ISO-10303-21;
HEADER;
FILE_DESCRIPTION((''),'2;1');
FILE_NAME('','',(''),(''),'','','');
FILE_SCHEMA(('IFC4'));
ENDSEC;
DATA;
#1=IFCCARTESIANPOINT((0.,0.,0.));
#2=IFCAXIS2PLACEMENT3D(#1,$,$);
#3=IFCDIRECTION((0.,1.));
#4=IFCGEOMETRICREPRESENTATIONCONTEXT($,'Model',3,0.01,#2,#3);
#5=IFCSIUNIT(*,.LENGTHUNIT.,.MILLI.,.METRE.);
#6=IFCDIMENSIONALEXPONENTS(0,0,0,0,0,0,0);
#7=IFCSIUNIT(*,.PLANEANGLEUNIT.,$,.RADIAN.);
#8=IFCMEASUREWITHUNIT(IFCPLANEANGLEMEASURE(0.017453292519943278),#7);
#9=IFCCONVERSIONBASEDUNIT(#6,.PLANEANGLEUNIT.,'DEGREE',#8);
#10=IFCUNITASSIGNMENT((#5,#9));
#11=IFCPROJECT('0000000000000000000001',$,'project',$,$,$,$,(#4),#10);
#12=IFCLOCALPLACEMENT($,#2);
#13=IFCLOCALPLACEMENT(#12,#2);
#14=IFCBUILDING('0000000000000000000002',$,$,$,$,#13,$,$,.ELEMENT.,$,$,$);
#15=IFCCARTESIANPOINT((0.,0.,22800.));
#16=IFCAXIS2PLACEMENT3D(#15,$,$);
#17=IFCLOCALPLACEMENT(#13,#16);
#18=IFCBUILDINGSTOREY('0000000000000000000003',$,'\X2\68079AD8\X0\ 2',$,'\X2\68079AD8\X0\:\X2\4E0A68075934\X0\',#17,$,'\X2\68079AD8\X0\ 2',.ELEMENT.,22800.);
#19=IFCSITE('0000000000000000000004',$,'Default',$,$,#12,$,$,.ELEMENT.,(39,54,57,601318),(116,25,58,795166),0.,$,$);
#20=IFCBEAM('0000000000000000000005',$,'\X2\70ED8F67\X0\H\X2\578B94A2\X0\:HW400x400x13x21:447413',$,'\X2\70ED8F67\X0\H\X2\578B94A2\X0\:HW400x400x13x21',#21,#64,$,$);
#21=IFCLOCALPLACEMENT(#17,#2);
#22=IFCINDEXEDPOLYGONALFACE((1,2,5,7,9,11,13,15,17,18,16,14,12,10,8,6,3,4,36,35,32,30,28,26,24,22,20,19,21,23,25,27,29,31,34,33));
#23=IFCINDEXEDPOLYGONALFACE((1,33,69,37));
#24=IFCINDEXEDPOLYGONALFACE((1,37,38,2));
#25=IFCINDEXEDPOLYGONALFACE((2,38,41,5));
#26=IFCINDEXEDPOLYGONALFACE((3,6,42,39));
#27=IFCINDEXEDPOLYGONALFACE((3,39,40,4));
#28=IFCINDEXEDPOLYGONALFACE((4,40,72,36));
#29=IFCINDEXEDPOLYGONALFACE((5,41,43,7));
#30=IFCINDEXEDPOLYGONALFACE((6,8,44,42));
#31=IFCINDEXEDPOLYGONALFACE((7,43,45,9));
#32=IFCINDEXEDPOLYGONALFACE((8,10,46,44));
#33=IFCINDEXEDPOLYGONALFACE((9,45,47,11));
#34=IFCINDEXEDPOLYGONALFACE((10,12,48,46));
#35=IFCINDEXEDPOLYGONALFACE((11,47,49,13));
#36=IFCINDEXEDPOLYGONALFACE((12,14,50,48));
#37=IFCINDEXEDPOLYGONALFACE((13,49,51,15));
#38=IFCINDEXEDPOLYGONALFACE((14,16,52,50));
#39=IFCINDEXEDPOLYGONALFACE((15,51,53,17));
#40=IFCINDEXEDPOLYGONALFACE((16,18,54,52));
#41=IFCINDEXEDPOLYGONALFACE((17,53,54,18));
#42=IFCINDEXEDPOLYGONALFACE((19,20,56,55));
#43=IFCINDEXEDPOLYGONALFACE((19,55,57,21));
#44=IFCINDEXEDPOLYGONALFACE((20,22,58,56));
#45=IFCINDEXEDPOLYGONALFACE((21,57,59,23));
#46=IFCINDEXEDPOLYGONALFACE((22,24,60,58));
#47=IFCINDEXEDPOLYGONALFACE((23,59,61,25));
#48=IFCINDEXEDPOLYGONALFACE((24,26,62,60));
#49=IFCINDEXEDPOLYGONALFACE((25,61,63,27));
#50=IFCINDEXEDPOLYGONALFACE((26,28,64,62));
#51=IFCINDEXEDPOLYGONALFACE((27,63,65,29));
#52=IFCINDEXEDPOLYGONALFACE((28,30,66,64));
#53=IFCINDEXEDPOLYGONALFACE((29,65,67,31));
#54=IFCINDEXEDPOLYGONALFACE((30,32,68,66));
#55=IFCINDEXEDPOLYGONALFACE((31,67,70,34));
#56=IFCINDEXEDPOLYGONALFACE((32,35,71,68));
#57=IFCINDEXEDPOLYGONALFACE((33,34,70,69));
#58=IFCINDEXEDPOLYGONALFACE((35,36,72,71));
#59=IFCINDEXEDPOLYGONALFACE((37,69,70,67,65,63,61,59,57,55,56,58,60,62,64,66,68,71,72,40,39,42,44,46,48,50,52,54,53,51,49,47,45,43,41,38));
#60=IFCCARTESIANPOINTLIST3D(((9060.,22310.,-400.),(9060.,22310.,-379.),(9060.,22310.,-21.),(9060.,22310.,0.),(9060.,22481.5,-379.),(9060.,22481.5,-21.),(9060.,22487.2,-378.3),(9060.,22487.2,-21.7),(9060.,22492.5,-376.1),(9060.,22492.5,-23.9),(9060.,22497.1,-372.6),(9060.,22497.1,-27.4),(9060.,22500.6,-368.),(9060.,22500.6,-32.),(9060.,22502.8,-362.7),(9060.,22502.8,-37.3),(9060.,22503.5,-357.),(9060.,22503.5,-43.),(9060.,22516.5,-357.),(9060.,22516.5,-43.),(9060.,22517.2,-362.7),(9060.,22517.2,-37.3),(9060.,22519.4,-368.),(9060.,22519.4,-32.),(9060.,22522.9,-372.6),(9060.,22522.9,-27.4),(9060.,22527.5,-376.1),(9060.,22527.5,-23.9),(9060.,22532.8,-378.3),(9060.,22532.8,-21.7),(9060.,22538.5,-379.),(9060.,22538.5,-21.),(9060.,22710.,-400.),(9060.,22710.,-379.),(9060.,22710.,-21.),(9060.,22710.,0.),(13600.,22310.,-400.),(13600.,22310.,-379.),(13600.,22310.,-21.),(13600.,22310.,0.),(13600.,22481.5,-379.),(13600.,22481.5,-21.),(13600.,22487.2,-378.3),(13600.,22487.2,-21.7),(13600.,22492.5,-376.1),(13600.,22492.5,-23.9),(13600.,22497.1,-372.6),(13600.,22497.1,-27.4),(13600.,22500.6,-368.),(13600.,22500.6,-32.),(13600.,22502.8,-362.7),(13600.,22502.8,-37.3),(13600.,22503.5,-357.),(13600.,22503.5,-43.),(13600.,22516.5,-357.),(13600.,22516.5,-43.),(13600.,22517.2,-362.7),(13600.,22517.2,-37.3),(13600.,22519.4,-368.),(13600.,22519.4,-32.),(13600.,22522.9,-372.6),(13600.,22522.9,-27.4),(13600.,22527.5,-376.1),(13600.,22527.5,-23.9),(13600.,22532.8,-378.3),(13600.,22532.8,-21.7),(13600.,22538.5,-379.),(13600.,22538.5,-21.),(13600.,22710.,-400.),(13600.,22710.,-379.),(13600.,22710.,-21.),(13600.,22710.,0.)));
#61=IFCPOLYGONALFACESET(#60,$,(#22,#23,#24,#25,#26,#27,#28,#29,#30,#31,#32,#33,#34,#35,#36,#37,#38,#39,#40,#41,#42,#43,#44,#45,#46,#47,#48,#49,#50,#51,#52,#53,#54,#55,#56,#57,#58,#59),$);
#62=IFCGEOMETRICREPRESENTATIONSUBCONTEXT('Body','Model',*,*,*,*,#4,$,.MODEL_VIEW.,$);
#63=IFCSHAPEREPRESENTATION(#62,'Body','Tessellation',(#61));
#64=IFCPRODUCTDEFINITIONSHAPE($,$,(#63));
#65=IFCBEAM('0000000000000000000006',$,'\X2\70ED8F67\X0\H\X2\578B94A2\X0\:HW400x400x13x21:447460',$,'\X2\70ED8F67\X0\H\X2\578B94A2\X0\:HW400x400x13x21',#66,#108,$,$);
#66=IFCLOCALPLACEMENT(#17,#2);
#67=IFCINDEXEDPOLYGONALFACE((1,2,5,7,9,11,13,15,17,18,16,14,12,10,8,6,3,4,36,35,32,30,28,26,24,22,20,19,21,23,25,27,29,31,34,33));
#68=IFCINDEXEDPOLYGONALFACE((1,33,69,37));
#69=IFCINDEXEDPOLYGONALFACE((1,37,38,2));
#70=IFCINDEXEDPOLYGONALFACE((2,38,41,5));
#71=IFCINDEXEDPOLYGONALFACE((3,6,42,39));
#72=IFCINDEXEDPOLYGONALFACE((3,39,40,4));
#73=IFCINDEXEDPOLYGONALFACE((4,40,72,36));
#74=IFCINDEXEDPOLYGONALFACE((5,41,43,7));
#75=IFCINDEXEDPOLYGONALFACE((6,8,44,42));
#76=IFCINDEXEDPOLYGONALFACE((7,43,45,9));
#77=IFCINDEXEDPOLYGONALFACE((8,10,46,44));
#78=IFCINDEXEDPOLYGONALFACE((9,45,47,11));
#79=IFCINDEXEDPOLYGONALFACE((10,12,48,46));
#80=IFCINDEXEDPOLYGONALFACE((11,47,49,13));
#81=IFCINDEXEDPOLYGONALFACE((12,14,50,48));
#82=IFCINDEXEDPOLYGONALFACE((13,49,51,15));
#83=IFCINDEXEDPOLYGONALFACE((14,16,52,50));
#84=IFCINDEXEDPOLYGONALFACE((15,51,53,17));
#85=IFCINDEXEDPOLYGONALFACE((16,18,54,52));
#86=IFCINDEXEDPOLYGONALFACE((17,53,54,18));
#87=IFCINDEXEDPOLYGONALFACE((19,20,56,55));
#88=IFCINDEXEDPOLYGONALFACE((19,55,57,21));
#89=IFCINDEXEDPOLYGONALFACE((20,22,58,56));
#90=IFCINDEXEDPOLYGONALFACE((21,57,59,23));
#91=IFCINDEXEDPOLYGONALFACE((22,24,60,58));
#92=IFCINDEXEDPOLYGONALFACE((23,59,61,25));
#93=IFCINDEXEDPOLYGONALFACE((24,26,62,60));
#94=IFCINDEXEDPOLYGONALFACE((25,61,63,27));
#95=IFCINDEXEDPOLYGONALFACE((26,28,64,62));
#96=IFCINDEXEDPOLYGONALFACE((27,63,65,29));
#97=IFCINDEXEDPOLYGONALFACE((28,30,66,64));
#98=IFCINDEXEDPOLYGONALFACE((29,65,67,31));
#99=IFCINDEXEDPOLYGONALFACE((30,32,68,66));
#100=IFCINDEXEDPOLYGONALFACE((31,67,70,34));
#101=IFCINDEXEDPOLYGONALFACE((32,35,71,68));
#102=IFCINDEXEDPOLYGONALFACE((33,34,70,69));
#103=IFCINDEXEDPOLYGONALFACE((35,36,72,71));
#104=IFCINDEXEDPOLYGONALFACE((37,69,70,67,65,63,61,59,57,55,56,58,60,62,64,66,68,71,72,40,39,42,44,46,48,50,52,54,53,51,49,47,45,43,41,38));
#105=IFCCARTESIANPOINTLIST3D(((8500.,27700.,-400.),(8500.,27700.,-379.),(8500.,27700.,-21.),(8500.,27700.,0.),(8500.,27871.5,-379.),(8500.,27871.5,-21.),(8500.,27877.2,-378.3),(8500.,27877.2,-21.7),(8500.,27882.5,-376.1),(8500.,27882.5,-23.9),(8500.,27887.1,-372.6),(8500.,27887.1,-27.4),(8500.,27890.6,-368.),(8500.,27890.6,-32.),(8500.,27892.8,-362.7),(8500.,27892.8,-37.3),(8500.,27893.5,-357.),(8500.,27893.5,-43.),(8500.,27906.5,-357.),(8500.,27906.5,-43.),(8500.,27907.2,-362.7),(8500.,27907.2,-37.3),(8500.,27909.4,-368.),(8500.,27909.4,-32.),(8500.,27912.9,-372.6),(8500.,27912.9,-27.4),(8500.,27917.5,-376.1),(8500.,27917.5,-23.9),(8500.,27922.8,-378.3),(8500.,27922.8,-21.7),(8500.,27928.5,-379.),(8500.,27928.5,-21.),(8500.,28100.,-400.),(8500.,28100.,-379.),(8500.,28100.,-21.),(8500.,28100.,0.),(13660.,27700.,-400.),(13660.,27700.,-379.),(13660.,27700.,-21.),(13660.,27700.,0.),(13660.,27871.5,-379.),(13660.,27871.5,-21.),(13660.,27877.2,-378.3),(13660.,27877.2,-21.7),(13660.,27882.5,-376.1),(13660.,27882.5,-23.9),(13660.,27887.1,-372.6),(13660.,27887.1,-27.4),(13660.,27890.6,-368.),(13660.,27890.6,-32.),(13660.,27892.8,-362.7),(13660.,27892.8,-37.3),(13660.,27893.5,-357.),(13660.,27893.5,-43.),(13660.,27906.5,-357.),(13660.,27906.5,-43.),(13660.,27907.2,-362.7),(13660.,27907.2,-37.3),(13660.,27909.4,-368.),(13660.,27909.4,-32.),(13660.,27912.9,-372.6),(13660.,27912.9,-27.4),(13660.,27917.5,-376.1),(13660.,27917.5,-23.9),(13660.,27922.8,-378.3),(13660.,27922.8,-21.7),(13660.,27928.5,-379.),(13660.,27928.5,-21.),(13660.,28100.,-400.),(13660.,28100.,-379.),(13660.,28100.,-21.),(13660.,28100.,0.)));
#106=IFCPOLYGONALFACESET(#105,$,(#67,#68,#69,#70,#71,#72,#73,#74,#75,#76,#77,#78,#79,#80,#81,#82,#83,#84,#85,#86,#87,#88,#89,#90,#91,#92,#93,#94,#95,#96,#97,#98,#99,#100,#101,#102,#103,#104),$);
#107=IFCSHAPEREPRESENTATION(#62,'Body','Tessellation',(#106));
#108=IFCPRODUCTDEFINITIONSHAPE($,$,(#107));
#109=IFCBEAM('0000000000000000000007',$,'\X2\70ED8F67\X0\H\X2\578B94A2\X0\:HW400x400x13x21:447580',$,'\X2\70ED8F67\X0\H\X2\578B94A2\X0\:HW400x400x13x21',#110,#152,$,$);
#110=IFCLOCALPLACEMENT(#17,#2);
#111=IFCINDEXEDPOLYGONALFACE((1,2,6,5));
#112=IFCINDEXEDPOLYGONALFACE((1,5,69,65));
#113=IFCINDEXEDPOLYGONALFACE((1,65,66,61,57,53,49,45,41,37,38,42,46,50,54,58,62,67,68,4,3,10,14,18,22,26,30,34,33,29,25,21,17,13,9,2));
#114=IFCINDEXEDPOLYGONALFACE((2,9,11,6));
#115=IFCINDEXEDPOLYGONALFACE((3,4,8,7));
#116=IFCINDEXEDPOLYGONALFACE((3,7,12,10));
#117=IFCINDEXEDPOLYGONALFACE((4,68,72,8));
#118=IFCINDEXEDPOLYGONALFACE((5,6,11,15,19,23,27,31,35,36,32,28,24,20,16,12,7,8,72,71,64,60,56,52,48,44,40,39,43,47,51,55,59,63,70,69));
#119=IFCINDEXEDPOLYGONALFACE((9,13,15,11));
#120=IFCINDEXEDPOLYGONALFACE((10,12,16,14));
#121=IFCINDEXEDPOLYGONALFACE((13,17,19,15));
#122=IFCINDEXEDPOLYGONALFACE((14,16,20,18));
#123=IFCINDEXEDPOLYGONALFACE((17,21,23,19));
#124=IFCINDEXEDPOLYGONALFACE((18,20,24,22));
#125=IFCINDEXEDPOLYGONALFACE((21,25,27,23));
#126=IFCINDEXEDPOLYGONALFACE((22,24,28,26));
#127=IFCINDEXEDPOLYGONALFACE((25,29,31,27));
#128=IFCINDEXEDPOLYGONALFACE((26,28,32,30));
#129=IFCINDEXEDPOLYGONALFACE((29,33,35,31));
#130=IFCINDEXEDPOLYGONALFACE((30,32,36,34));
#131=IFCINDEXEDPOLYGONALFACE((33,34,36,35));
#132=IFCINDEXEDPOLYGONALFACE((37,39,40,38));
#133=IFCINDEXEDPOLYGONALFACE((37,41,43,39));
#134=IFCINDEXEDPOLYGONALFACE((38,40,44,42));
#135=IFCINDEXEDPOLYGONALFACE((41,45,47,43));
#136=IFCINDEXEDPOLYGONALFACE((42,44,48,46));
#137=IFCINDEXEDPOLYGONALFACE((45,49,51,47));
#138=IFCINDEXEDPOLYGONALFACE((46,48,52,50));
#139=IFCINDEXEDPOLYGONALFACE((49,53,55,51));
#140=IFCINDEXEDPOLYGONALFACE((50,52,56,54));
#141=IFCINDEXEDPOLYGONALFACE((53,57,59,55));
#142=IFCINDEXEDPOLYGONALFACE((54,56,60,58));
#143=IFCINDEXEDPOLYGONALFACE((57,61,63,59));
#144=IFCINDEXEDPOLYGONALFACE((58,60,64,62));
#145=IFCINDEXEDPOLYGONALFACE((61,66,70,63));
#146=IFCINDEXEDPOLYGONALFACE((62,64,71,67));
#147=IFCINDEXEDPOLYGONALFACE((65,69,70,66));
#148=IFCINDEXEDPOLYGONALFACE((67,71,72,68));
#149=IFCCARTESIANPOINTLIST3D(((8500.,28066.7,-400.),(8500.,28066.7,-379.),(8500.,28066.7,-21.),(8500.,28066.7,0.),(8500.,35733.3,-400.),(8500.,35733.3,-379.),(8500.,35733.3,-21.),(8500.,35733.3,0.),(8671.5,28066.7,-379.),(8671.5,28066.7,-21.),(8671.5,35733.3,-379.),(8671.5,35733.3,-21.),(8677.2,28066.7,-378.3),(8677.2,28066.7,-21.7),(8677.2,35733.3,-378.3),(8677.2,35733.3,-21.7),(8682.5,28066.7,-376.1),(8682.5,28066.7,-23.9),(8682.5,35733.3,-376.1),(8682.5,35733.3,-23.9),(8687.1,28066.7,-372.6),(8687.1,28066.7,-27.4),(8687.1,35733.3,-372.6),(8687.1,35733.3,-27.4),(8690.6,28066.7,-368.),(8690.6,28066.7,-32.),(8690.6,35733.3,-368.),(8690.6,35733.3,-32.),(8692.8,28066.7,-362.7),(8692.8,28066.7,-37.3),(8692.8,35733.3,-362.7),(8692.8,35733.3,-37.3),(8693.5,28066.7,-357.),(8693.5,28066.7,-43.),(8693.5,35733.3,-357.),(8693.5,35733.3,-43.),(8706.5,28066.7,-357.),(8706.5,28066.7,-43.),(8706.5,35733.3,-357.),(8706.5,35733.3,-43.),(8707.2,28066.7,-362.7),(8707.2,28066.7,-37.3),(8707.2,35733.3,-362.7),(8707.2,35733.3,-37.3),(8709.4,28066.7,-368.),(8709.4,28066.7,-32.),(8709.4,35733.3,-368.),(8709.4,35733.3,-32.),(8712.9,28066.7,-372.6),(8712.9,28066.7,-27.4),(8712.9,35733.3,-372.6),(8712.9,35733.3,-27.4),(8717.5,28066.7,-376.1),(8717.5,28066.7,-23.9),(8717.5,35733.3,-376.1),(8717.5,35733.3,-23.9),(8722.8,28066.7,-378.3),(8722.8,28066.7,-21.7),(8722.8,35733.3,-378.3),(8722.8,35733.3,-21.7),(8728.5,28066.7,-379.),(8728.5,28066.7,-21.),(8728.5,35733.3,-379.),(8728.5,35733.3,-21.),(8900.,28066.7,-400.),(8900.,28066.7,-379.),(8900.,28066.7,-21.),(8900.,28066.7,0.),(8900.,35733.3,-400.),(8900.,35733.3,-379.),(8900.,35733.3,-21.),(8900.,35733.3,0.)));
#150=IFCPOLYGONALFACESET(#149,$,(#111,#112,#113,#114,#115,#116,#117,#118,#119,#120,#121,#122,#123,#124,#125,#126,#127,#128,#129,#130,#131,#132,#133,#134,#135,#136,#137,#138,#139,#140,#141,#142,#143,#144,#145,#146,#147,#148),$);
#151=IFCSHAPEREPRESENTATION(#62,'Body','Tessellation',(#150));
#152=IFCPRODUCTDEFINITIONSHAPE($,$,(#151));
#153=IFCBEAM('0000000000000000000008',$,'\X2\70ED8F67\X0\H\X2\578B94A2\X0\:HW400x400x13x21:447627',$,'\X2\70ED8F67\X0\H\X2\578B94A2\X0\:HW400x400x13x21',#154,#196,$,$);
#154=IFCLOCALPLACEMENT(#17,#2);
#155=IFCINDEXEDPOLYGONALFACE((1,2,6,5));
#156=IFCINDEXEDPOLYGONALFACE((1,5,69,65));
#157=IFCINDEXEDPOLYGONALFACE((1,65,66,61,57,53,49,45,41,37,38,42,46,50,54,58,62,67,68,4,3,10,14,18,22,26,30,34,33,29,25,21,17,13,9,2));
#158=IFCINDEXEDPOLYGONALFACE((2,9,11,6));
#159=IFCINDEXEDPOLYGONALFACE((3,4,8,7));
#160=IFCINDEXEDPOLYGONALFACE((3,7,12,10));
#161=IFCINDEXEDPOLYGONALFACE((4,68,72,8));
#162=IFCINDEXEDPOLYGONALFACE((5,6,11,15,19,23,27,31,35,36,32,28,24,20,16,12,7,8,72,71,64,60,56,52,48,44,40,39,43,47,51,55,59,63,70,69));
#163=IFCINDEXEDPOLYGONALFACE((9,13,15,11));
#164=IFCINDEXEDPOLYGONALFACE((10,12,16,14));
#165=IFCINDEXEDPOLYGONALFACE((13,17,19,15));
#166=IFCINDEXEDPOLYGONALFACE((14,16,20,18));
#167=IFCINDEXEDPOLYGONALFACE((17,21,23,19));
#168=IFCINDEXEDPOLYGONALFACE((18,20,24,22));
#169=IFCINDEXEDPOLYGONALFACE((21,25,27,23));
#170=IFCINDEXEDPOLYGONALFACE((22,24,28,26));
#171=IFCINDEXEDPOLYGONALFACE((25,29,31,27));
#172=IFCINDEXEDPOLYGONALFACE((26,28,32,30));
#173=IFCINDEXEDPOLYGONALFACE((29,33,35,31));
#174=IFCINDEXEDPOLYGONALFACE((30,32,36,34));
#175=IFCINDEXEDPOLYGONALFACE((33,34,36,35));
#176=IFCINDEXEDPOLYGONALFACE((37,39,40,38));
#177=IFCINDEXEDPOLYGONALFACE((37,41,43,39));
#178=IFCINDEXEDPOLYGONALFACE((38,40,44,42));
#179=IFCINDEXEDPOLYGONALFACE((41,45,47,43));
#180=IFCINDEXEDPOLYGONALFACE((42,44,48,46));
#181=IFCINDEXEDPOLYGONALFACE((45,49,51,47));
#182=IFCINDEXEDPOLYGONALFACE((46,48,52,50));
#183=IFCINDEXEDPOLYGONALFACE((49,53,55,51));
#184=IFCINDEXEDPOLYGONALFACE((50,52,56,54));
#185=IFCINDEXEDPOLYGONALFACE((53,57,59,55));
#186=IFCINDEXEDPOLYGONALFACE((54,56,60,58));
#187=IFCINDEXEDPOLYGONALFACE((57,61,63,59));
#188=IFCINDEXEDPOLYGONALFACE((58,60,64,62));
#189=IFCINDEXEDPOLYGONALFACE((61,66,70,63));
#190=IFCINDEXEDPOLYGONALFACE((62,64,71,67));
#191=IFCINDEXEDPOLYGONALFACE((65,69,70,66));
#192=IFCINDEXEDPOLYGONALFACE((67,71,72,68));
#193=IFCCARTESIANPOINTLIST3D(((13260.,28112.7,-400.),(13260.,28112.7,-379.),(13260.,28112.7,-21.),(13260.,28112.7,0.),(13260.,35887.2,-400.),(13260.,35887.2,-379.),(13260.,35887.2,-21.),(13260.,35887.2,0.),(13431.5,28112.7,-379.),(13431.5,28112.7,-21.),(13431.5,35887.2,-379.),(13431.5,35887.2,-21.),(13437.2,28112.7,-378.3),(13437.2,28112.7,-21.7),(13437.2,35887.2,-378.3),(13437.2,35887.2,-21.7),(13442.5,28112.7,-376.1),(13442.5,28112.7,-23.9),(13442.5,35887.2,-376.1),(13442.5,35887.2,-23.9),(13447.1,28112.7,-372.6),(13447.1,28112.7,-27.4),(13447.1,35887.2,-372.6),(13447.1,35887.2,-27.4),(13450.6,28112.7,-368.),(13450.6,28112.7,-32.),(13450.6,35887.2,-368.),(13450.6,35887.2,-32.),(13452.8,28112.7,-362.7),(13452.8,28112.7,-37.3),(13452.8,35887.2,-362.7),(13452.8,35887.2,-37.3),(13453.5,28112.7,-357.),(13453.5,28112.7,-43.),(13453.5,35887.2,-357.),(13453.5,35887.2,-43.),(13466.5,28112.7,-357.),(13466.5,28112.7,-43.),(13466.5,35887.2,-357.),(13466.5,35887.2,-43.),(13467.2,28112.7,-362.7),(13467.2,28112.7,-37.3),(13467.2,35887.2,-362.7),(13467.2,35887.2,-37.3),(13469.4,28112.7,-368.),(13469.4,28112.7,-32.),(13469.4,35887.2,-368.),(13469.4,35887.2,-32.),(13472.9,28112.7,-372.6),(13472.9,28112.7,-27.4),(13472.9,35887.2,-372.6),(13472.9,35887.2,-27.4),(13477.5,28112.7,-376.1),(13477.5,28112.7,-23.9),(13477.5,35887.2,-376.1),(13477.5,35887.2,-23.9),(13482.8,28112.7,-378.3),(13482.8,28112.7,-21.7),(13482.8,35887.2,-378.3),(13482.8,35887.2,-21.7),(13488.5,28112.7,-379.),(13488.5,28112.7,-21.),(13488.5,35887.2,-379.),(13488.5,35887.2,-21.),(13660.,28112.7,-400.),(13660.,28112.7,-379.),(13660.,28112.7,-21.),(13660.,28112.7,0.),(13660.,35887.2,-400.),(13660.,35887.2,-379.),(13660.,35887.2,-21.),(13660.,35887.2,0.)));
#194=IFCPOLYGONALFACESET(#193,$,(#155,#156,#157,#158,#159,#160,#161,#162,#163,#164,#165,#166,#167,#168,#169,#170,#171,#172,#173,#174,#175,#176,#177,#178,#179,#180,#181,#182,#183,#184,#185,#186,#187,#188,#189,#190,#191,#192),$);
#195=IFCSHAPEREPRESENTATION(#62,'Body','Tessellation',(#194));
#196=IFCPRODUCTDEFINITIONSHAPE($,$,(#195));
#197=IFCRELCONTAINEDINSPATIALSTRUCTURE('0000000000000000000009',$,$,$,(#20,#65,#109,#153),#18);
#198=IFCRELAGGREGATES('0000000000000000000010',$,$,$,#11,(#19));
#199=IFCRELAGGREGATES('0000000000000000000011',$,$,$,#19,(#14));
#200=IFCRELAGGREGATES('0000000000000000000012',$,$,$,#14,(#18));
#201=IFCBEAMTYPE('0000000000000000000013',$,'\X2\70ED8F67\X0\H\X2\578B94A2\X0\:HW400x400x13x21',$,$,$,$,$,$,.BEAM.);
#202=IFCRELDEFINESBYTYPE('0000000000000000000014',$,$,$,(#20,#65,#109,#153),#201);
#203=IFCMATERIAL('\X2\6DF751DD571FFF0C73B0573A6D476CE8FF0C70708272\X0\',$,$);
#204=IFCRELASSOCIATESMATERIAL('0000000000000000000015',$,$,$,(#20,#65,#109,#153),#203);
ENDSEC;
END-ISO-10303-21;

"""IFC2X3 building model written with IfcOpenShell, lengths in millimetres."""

from ifc_helpers import new_model, entity, si_unit, converted_unit, direction, frame, frame_2d, origin, place, context, subcontext, project, spatial, i_section, extrude, material, type_object, element, save


model = new_model("IFC2X3")

# Units and contexts
model_context = context("Model", 3, precision=0.01, world=origin(), true_north=direction((0.0, 1.0)))
body_context = subcontext(model_context, "Body", "Model", "MODEL_VIEW")
ifc_project = project(units=[si_unit("LENGTHUNIT", "METRE", prefix="MILLI"), converted_unit("PLANEANGLEUNIT", "DEGREE", entity("IfcPlaneAngleMeasure", 0.017453292519943278), si_unit("PLANEANGLEUNIT", "RADIAN"), dimensions=[0, 0, 0, 0, 0, 0, 0])], contexts=[model_context])

# Site, building, storey
site_placement = place(None, origin())
site = spatial("IfcSite", under=ifc_project, at=site_placement, Name="Default", CompositionType="ELEMENT", RefLatitude=(39, 54, 57, 601318), RefLongitude=(116, 25, 58, 795166), RefElevation=0.0)
building_placement = place(site_placement, origin())
building = spatial("IfcBuilding", under=site, at=building_placement, CompositionType="ELEMENT")
storey_placement = place(building_placement, frame((0.0, 0.0, 22800.0)))
storey = spatial("IfcBuildingStorey", under=building, at=storey_placement, Name="标高 2", ObjectType="标高:上标头", LongName="标高 2", CompositionType="ELEMENT", Elevation=22800.0)

# Beams
ifc_material = material(Name="混凝土，现场浇注，灰色")
beam_type = type_object("IfcBeamType", Name="热轧H型钢:HW400x400x13x21", PredefinedType="BEAM")
beam_1_placement = place(storey_placement, frame((9060.0, 22510.0, 0.0)))
element("IfcBeam", 1, at=beam_1_placement, inside=storey, type_object=beam_type, material=ifc_material, Name="热轧H型钢:HW400x400x13x21:447413", ObjectType="热轧H型钢:HW400x400x13x21", context=body_context, shape_type="SweptSolid", body=[
    extrude(i_section(OverallWidth=400.0, OverallDepth=400.0, WebThickness=13.0, FlangeThickness=21.0, FilletRadius=22.0, at=frame_2d((0.0, 0.0), x_axis=(0.0, 1.0))), frame((0.0, 0.0, -200.0), z_axis=(1.0, 0.0, 0.0), x_axis=(0.0, 0.0, -1.0)), (0.0, 0.0, 1.0), 4540.0),
])
beam_2_placement = place(storey_placement, frame((13460.0, 27900.0, 0.0), z_axis=(0.0, 0.0, 1.0), x_axis=(-1.0, 0.0, 0.0)))
element("IfcBeam", 2, at=beam_2_placement, inside=storey, type_object=beam_type, material=ifc_material, Name="热轧H型钢:HW400x400x13x21:447460", ObjectType="热轧H型钢:HW400x400x13x21", context=body_context, shape_type="SweptSolid", body=[
    extrude(i_section(OverallWidth=400.0, OverallDepth=400.0, WebThickness=13.0, FlangeThickness=21.0, FilletRadius=22.0, at=frame_2d((0.0, 0.0), x_axis=(0.0, 1.0))), frame((-200.0, 0.0, -200.0), z_axis=(1.0, 0.0, 0.0), x_axis=(0.0, 0.0, -1.0)), (0.0, 0.0, 1.0), 5160.0),
])
beam_3_placement = place(storey_placement, frame((8700.0, 27900.0, 0.0), z_axis=(0.0, 0.0, 1.0), x_axis=(0.0, 1.0, 0.0)))
element("IfcBeam", 3, at=beam_3_placement, inside=storey, type_object=beam_type, material=ifc_material, Name="热轧H型钢:HW400x400x13x21:447580", ObjectType="热轧H型钢:HW400x400x13x21", context=body_context, shape_type="SweptSolid", body=[
    extrude(i_section(OverallWidth=400.0, OverallDepth=400.0, WebThickness=13.0, FlangeThickness=21.0, FilletRadius=22.0, at=frame_2d((0.0, 0.0), x_axis=(0.0, 1.0))), frame((166.7, 0.0, -200.0), z_axis=(1.0, 0.0, 0.0), x_axis=(0.0, 0.0, -1.0)), (0.0, 0.0, 1.0), 7666.6),
])
beam_4_placement = place(storey_placement, frame((13460.0, 35900.0, 0.0), z_axis=(0.0, 0.0, 1.0), x_axis=(0.0, -1.0, 0.0)))
element("IfcBeam", 4, at=beam_4_placement, inside=storey, type_object=beam_type, material=ifc_material, Name="热轧H型钢:HW400x400x13x21:447627", ObjectType="热轧H型钢:HW400x400x13x21", context=body_context, shape_type="SweptSolid", body=[
    extrude(i_section(OverallWidth=400.0, OverallDepth=400.0, WebThickness=13.0, FlangeThickness=21.0, FilletRadius=22.0, at=frame_2d((0.0, 0.0), x_axis=(0.0, 1.0))), frame((12.8, 0.0, -200.0), z_axis=(1.0, 0.0, 0.0), x_axis=(0.0, 0.0, -1.0)), (0.0, 0.0, 1.0), 7774.5),
])

save(model, "model.ifc")
